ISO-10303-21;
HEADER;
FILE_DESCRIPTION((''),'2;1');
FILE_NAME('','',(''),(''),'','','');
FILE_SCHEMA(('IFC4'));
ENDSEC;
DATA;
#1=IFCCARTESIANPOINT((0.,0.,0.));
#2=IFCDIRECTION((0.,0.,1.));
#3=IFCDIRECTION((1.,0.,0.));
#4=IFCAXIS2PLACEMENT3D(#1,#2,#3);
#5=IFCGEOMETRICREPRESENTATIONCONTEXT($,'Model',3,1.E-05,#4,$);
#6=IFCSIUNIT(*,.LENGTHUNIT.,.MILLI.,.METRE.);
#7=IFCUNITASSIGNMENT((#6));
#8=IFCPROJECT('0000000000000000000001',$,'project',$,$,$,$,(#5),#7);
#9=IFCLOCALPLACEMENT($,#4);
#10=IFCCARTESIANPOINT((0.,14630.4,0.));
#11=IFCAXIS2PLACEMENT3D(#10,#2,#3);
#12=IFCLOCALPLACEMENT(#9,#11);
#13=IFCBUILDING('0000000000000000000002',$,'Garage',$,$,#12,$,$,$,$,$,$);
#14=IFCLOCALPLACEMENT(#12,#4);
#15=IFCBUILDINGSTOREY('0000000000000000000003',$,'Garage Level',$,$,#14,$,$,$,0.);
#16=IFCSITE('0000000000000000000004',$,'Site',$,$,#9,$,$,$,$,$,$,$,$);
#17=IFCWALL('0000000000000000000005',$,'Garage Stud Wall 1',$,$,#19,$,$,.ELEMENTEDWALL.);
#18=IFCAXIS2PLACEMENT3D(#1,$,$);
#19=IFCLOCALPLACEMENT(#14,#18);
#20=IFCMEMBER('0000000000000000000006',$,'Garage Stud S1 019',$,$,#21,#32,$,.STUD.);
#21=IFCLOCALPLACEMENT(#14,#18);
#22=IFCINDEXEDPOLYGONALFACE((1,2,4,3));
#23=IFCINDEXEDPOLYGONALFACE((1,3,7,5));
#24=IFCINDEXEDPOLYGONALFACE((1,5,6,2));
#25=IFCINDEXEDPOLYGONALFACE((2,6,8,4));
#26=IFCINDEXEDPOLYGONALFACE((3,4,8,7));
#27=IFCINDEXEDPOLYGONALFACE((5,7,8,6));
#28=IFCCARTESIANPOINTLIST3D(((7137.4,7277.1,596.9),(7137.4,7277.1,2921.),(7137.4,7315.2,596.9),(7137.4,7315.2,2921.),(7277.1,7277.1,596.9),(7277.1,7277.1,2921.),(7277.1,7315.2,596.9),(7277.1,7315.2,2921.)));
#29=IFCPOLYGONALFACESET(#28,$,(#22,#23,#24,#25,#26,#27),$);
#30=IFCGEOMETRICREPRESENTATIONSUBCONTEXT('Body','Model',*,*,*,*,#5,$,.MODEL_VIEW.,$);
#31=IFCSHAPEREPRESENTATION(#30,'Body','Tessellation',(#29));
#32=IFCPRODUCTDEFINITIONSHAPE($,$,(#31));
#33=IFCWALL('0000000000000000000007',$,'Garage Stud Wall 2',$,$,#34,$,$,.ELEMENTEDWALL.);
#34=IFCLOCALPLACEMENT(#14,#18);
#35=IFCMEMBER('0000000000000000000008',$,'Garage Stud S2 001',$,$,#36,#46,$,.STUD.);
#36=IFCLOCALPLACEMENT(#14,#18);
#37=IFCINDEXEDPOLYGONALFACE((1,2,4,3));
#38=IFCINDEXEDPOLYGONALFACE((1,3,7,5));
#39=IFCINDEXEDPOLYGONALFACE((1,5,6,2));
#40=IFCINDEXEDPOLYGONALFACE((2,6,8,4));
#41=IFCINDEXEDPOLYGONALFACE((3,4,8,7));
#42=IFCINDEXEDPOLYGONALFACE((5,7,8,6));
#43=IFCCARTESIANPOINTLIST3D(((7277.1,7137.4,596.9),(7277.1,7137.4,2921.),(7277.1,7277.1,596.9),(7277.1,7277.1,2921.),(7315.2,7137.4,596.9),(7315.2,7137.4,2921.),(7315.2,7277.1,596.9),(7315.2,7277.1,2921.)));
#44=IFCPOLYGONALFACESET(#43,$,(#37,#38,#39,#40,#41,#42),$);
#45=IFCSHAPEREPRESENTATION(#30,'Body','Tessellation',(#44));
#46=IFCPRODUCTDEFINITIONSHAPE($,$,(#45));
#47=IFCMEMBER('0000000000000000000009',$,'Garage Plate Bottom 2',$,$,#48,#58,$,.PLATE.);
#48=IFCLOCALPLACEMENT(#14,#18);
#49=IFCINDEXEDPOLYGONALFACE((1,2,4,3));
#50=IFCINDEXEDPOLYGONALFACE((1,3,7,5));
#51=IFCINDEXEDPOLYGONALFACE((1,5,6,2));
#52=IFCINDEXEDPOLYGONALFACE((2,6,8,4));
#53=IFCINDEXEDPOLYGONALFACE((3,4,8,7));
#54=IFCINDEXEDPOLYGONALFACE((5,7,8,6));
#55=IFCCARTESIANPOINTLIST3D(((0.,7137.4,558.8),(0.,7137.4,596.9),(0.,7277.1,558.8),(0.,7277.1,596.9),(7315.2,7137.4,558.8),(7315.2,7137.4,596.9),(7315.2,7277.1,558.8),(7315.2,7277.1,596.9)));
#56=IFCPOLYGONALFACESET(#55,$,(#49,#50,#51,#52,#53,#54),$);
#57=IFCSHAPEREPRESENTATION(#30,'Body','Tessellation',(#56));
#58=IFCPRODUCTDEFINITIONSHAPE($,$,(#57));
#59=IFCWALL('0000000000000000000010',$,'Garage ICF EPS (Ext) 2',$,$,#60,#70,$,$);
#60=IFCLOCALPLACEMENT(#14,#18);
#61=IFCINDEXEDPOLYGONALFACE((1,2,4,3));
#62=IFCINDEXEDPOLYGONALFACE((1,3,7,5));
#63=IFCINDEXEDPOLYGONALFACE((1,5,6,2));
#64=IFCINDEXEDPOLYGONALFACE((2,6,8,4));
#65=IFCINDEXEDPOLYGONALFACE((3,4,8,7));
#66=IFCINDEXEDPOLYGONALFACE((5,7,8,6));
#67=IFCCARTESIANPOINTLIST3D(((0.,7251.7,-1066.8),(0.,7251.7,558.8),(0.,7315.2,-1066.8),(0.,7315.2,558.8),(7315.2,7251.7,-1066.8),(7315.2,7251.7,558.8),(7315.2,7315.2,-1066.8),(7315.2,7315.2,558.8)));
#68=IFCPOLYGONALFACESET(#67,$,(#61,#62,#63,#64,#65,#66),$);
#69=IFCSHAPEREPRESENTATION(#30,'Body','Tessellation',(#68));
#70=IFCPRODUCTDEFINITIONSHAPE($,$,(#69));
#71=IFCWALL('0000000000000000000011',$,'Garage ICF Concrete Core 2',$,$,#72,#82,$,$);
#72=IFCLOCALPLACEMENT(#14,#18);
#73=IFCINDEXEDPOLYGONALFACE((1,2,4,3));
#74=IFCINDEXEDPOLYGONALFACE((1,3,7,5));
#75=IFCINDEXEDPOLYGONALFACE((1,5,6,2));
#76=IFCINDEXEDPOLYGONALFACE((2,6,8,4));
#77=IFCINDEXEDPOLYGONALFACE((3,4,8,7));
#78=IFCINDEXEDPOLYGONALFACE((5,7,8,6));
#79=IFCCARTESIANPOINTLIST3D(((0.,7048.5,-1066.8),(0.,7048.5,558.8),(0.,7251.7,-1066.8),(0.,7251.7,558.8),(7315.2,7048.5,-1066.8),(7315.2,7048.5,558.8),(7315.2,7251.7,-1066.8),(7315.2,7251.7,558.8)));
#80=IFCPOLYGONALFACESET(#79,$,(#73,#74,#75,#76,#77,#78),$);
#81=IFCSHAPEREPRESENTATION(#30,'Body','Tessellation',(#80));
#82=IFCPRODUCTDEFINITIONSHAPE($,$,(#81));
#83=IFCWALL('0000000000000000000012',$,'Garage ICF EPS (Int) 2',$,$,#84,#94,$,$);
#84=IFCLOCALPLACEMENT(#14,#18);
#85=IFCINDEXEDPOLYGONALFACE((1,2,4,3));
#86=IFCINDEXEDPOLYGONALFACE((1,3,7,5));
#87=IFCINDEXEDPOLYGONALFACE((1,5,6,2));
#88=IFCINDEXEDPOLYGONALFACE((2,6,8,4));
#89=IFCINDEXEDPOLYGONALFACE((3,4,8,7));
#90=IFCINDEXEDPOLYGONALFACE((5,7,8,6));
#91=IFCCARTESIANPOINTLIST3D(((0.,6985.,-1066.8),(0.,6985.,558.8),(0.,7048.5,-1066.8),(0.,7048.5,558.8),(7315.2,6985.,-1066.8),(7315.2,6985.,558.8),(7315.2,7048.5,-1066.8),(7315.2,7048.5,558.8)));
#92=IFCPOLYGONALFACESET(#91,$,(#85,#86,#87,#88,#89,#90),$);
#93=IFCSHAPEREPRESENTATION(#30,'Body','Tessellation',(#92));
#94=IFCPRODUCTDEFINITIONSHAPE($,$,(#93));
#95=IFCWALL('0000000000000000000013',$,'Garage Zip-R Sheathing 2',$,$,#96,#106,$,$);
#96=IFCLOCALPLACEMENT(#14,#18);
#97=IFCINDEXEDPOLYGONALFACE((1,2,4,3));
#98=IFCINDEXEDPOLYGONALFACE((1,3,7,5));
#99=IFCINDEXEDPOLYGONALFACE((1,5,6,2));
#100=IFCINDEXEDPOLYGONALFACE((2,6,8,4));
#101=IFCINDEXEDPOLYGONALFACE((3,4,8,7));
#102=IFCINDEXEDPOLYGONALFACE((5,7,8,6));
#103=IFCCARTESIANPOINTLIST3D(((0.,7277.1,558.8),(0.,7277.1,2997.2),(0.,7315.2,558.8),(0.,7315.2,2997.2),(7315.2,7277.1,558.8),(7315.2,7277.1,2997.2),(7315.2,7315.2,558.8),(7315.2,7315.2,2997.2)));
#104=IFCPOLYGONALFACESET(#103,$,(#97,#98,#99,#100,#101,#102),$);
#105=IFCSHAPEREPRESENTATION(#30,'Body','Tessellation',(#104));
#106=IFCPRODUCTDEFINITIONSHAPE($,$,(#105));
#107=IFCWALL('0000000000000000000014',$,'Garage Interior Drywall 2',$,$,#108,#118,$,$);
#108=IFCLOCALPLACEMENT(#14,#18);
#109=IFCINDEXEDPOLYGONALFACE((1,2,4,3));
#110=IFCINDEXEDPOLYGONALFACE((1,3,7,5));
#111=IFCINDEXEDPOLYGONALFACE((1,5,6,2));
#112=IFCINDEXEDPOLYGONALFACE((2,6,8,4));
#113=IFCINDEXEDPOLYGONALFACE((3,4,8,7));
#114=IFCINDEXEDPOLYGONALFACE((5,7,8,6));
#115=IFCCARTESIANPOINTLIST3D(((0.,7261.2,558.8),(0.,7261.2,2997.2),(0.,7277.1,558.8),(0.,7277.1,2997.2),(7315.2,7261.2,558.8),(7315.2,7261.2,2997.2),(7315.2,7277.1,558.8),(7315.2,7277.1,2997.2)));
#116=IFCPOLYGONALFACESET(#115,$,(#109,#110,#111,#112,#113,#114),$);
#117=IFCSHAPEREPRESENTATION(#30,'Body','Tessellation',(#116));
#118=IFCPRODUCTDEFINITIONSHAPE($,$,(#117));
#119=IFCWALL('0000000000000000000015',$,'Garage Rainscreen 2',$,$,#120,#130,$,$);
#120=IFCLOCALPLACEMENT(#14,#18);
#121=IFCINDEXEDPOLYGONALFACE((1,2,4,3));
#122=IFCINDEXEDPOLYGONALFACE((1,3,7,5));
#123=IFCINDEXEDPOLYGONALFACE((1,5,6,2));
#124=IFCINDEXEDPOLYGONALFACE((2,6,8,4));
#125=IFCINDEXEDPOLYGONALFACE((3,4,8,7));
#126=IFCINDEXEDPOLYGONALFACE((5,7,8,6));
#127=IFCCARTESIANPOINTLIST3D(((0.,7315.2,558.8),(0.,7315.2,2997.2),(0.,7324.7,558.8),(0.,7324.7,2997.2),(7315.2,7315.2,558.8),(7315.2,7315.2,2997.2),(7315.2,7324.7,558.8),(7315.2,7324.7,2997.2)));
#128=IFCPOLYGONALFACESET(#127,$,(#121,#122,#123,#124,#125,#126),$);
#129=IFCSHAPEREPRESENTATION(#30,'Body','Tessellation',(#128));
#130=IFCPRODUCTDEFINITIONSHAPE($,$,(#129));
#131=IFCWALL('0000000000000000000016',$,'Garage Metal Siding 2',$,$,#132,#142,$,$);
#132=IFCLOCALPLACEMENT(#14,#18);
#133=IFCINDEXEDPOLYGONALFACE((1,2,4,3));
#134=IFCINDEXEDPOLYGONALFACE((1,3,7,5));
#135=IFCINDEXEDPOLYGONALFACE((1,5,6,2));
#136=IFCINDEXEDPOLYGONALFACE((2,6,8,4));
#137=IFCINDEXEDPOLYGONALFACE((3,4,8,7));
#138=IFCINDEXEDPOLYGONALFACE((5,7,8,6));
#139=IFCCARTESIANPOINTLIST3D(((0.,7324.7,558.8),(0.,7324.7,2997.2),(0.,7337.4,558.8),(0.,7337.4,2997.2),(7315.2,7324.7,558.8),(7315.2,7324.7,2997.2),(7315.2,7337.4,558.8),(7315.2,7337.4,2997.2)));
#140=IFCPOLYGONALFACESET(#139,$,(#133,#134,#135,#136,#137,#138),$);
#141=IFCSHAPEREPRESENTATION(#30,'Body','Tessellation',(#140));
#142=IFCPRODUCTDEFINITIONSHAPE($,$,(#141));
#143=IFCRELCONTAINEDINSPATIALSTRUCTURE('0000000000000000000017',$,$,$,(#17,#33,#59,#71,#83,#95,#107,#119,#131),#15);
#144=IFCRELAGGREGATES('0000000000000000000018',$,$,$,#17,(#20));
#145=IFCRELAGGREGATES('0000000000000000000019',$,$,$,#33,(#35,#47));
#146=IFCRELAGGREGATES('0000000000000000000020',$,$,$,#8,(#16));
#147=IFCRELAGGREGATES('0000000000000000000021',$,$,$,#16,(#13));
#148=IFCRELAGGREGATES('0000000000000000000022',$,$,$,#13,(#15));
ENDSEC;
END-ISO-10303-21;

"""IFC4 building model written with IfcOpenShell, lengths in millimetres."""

from ifc_helpers import new_model, si_unit, frame, origin_with_axes, origin_2d, place, context, subcontext, project, spatial, indexed_curve, rectangle, outline, extrude, element, aggregate, save


model = new_model("IFC4")

# Units and contexts
model_context = context("Model", 3, precision=1e-05, world=origin_with_axes())
body_context = subcontext(model_context, "Body", "Model", "MODEL_VIEW")
ifc_project = project(units=[si_unit("LENGTHUNIT", "METRE", prefix="MILLI")], contexts=[model_context])

# Site, building, storey
site_placement = place(None, origin_with_axes())
site = spatial("IfcSite", under=ifc_project, at=site_placement, Name="Site")
building_placement = place(site_placement, frame((0.0, 14630.4, 0.0), z_axis=(0.0, 0.0, 1.0), x_axis=(1.0, 0.0, 0.0)))
building = spatial("IfcBuilding", under=site, at=building_placement, Name="Garage")
storey_placement = place(building_placement, origin_with_axes())
storey = spatial("IfcBuildingStorey", under=building, at=storey_placement, Name="Garage Level", Elevation=0.0)

# Walls, members
wall_1_placement = place(storey_placement, frame((7315.2, 0.0, 558.8), z_axis=(0.0, 0.0, 1.0), x_axis=(0.0, 1.0, 0.0)))
wall_1 = element("IfcWall", 1, at=wall_1_placement, inside=storey, Name="Garage Stud Wall 1", PredefinedType="ELEMENTEDWALL")
member_1_placement = place(wall_1_placement, frame((7296.1, 108.0, 38.1), z_axis=(0.0, 0.0, 1.0), x_axis=(1.0, 0.0, 0.0)))
member_1 = element("IfcMember", 2, at=member_1_placement, Name="Garage Stud S1 019", PredefinedType="STUD", context=body_context, shape_type="SweptSolid", body=[
    extrude(rectangle(XDim=38.1, YDim=139.7, at=origin_2d()), origin_with_axes(), (0.0, 0.0, 1.0), 2324.1),
])
aggregate(wall_1, [member_1])
wall_2_placement = place(storey_placement, frame((7315.2, 7315.2, 558.8), z_axis=(0.0, 0.0, 1.0), x_axis=(-1.0, 0.0, 0.0)))
wall_2 = element("IfcWall", 3, at=wall_2_placement, inside=storey, Name="Garage Stud Wall 2", PredefinedType="ELEMENTEDWALL")
member_2_placement = place(wall_2_placement, frame((19.1, 107.9, 38.1), z_axis=(0.0, 0.0, 1.0), x_axis=(1.0, 0.0, 0.0)))
member_2 = element("IfcMember", 4, at=member_2_placement, Name="Garage Stud S2 001", PredefinedType="STUD", context=body_context, shape_type="SweptSolid", body=[
    extrude(rectangle(XDim=38.1, YDim=139.7, at=origin_2d()), origin_with_axes(), (0.0, 0.0, 1.0), 2324.1),
])
member_3_placement = place(wall_2_placement, frame((0.0, 107.9, 19.1), z_axis=(1.0, 0.0, 0.0), x_axis=(0.0, 0.0, 1.0)))
member_3 = element("IfcMember", 5, at=member_3_placement, Name="Garage Plate Bottom 2", PredefinedType="PLATE", context=body_context, shape_type="SweptSolid", body=[
    extrude(rectangle(XDim=38.1, YDim=139.7, at=origin_2d()), origin_with_axes(), (0.0, 0.0, 1.0), 7315.2),
])
aggregate(wall_2, [member_2, member_3])

# Walls
wall_3_placement = place(storey_placement, frame((7315.2, 7315.2, -1066.8), z_axis=(0.0, 0.0, 1.0), x_axis=(-1.0, 0.0, 0.0)))
element("IfcWall", 6, at=wall_3_placement, inside=storey, Name="Garage ICF EPS (Ext) 2", context=body_context, shape_type="SweptSolid", body=[
    extrude(outline(indexed_curve([(0.0, 0.0), (0.0, 63.5), (7315.2, 63.5), (7315.2, 0.0), (0.0, 0.0)], self_intersect=False)), origin_with_axes(), (0.0, 0.0, 1.0), 1625.6),
])
wall_4_placement = place(storey_placement, frame((7315.2, 7315.2, -1066.8), z_axis=(0.0, 0.0, 1.0), x_axis=(-1.0, 0.0, 0.0)))
element("IfcWall", 7, at=wall_4_placement, inside=storey, Name="Garage ICF Concrete Core 2", context=body_context, shape_type="SweptSolid", body=[
    extrude(outline(indexed_curve([(0.0, 0.0), (0.0, 203.2), (7315.2, 203.2), (7315.2, 0.0), (0.0, 0.0)], self_intersect=False)), frame((0.0, 63.5, 0.0), z_axis=(0.0, 0.0, 1.0), x_axis=(1.0, 0.0, 0.0)), (0.0, 0.0, 1.0), 1625.6),
])
wall_5_placement = place(storey_placement, frame((7315.2, 7315.2, -1066.8), z_axis=(0.0, 0.0, 1.0), x_axis=(-1.0, 0.0, 0.0)))
element("IfcWall", 8, at=wall_5_placement, inside=storey, Name="Garage ICF EPS (Int) 2", context=body_context, shape_type="SweptSolid", body=[
    extrude(outline(indexed_curve([(0.0, 0.0), (0.0, 63.5), (7315.2, 63.5), (7315.2, 0.0), (0.0, 0.0)], self_intersect=False)), frame((0.0, 266.7, 0.0), z_axis=(0.0, 0.0, 1.0), x_axis=(1.0, 0.0, 0.0)), (0.0, 0.0, 1.0), 1625.6),
])
wall_6_placement = place(storey_placement, frame((7315.2, 7315.2, 558.8), z_axis=(0.0, 0.0, 1.0), x_axis=(-1.0, 0.0, 0.0)))
element("IfcWall", 9, at=wall_6_placement, inside=storey, Name="Garage Zip-R Sheathing 2", context=body_context, shape_type="SweptSolid", body=[
    extrude(outline(indexed_curve([(0.0, 0.0), (0.0, 38.1), (7315.2, 38.1), (7315.2, 0.0), (0.0, 0.0)], self_intersect=False)), origin_with_axes(), (0.0, 0.0, 1.0), 2438.4),
])
wall_7_placement = place(storey_placement, frame((7315.2, 7315.2, 558.8), z_axis=(0.0, 0.0, 1.0), x_axis=(-1.0, 0.0, 0.0)))
element("IfcWall", 10, at=wall_7_placement, inside=storey, Name="Garage Interior Drywall 2", context=body_context, shape_type="SweptSolid", body=[
    extrude(outline(indexed_curve([(0.0, 0.0), (0.0, 15.9), (7315.2, 15.9), (7315.2, 0.0), (0.0, 0.0)], self_intersect=False)), frame((0.0, 38.1, 0.0), z_axis=(0.0, 0.0, 1.0), x_axis=(1.0, 0.0, 0.0)), (0.0, 0.0, 1.0), 2438.4),
])
wall_8_placement = place(storey_placement, frame((7315.2, 7315.2, 558.8), z_axis=(0.0, 0.0, 1.0), x_axis=(-1.0, 0.0, 0.0)))
element("IfcWall", 11, at=wall_8_placement, inside=storey, Name="Garage Rainscreen 2", context=body_context, shape_type="SweptSolid", body=[
    extrude(outline(indexed_curve([(0.0, 0.0), (0.0, -9.5), (7315.2, -9.5), (7315.2, 0.0), (0.0, 0.0)], self_intersect=False)), origin_with_axes(), (0.0, 0.0, 1.0), 2438.4),
])
wall_9_placement = place(storey_placement, frame((7315.2, 7315.2, 558.8), z_axis=(0.0, 0.0, 1.0), x_axis=(-1.0, 0.0, 0.0)))
element("IfcWall", 12, at=wall_9_placement, inside=storey, Name="Garage Metal Siding 2", context=body_context, shape_type="SweptSolid", body=[
    extrude(outline(indexed_curve([(0.0, 0.0), (0.0, -12.7), (7315.2, -12.7), (7315.2, 0.0), (0.0, 0.0)], self_intersect=False)), frame((0.0, -9.5, 0.0), z_axis=(0.0, 0.0, 1.0), x_axis=(1.0, 0.0, 0.0)), (0.0, 0.0, 1.0), 2438.4),
])

save(model, "model.ifc")
